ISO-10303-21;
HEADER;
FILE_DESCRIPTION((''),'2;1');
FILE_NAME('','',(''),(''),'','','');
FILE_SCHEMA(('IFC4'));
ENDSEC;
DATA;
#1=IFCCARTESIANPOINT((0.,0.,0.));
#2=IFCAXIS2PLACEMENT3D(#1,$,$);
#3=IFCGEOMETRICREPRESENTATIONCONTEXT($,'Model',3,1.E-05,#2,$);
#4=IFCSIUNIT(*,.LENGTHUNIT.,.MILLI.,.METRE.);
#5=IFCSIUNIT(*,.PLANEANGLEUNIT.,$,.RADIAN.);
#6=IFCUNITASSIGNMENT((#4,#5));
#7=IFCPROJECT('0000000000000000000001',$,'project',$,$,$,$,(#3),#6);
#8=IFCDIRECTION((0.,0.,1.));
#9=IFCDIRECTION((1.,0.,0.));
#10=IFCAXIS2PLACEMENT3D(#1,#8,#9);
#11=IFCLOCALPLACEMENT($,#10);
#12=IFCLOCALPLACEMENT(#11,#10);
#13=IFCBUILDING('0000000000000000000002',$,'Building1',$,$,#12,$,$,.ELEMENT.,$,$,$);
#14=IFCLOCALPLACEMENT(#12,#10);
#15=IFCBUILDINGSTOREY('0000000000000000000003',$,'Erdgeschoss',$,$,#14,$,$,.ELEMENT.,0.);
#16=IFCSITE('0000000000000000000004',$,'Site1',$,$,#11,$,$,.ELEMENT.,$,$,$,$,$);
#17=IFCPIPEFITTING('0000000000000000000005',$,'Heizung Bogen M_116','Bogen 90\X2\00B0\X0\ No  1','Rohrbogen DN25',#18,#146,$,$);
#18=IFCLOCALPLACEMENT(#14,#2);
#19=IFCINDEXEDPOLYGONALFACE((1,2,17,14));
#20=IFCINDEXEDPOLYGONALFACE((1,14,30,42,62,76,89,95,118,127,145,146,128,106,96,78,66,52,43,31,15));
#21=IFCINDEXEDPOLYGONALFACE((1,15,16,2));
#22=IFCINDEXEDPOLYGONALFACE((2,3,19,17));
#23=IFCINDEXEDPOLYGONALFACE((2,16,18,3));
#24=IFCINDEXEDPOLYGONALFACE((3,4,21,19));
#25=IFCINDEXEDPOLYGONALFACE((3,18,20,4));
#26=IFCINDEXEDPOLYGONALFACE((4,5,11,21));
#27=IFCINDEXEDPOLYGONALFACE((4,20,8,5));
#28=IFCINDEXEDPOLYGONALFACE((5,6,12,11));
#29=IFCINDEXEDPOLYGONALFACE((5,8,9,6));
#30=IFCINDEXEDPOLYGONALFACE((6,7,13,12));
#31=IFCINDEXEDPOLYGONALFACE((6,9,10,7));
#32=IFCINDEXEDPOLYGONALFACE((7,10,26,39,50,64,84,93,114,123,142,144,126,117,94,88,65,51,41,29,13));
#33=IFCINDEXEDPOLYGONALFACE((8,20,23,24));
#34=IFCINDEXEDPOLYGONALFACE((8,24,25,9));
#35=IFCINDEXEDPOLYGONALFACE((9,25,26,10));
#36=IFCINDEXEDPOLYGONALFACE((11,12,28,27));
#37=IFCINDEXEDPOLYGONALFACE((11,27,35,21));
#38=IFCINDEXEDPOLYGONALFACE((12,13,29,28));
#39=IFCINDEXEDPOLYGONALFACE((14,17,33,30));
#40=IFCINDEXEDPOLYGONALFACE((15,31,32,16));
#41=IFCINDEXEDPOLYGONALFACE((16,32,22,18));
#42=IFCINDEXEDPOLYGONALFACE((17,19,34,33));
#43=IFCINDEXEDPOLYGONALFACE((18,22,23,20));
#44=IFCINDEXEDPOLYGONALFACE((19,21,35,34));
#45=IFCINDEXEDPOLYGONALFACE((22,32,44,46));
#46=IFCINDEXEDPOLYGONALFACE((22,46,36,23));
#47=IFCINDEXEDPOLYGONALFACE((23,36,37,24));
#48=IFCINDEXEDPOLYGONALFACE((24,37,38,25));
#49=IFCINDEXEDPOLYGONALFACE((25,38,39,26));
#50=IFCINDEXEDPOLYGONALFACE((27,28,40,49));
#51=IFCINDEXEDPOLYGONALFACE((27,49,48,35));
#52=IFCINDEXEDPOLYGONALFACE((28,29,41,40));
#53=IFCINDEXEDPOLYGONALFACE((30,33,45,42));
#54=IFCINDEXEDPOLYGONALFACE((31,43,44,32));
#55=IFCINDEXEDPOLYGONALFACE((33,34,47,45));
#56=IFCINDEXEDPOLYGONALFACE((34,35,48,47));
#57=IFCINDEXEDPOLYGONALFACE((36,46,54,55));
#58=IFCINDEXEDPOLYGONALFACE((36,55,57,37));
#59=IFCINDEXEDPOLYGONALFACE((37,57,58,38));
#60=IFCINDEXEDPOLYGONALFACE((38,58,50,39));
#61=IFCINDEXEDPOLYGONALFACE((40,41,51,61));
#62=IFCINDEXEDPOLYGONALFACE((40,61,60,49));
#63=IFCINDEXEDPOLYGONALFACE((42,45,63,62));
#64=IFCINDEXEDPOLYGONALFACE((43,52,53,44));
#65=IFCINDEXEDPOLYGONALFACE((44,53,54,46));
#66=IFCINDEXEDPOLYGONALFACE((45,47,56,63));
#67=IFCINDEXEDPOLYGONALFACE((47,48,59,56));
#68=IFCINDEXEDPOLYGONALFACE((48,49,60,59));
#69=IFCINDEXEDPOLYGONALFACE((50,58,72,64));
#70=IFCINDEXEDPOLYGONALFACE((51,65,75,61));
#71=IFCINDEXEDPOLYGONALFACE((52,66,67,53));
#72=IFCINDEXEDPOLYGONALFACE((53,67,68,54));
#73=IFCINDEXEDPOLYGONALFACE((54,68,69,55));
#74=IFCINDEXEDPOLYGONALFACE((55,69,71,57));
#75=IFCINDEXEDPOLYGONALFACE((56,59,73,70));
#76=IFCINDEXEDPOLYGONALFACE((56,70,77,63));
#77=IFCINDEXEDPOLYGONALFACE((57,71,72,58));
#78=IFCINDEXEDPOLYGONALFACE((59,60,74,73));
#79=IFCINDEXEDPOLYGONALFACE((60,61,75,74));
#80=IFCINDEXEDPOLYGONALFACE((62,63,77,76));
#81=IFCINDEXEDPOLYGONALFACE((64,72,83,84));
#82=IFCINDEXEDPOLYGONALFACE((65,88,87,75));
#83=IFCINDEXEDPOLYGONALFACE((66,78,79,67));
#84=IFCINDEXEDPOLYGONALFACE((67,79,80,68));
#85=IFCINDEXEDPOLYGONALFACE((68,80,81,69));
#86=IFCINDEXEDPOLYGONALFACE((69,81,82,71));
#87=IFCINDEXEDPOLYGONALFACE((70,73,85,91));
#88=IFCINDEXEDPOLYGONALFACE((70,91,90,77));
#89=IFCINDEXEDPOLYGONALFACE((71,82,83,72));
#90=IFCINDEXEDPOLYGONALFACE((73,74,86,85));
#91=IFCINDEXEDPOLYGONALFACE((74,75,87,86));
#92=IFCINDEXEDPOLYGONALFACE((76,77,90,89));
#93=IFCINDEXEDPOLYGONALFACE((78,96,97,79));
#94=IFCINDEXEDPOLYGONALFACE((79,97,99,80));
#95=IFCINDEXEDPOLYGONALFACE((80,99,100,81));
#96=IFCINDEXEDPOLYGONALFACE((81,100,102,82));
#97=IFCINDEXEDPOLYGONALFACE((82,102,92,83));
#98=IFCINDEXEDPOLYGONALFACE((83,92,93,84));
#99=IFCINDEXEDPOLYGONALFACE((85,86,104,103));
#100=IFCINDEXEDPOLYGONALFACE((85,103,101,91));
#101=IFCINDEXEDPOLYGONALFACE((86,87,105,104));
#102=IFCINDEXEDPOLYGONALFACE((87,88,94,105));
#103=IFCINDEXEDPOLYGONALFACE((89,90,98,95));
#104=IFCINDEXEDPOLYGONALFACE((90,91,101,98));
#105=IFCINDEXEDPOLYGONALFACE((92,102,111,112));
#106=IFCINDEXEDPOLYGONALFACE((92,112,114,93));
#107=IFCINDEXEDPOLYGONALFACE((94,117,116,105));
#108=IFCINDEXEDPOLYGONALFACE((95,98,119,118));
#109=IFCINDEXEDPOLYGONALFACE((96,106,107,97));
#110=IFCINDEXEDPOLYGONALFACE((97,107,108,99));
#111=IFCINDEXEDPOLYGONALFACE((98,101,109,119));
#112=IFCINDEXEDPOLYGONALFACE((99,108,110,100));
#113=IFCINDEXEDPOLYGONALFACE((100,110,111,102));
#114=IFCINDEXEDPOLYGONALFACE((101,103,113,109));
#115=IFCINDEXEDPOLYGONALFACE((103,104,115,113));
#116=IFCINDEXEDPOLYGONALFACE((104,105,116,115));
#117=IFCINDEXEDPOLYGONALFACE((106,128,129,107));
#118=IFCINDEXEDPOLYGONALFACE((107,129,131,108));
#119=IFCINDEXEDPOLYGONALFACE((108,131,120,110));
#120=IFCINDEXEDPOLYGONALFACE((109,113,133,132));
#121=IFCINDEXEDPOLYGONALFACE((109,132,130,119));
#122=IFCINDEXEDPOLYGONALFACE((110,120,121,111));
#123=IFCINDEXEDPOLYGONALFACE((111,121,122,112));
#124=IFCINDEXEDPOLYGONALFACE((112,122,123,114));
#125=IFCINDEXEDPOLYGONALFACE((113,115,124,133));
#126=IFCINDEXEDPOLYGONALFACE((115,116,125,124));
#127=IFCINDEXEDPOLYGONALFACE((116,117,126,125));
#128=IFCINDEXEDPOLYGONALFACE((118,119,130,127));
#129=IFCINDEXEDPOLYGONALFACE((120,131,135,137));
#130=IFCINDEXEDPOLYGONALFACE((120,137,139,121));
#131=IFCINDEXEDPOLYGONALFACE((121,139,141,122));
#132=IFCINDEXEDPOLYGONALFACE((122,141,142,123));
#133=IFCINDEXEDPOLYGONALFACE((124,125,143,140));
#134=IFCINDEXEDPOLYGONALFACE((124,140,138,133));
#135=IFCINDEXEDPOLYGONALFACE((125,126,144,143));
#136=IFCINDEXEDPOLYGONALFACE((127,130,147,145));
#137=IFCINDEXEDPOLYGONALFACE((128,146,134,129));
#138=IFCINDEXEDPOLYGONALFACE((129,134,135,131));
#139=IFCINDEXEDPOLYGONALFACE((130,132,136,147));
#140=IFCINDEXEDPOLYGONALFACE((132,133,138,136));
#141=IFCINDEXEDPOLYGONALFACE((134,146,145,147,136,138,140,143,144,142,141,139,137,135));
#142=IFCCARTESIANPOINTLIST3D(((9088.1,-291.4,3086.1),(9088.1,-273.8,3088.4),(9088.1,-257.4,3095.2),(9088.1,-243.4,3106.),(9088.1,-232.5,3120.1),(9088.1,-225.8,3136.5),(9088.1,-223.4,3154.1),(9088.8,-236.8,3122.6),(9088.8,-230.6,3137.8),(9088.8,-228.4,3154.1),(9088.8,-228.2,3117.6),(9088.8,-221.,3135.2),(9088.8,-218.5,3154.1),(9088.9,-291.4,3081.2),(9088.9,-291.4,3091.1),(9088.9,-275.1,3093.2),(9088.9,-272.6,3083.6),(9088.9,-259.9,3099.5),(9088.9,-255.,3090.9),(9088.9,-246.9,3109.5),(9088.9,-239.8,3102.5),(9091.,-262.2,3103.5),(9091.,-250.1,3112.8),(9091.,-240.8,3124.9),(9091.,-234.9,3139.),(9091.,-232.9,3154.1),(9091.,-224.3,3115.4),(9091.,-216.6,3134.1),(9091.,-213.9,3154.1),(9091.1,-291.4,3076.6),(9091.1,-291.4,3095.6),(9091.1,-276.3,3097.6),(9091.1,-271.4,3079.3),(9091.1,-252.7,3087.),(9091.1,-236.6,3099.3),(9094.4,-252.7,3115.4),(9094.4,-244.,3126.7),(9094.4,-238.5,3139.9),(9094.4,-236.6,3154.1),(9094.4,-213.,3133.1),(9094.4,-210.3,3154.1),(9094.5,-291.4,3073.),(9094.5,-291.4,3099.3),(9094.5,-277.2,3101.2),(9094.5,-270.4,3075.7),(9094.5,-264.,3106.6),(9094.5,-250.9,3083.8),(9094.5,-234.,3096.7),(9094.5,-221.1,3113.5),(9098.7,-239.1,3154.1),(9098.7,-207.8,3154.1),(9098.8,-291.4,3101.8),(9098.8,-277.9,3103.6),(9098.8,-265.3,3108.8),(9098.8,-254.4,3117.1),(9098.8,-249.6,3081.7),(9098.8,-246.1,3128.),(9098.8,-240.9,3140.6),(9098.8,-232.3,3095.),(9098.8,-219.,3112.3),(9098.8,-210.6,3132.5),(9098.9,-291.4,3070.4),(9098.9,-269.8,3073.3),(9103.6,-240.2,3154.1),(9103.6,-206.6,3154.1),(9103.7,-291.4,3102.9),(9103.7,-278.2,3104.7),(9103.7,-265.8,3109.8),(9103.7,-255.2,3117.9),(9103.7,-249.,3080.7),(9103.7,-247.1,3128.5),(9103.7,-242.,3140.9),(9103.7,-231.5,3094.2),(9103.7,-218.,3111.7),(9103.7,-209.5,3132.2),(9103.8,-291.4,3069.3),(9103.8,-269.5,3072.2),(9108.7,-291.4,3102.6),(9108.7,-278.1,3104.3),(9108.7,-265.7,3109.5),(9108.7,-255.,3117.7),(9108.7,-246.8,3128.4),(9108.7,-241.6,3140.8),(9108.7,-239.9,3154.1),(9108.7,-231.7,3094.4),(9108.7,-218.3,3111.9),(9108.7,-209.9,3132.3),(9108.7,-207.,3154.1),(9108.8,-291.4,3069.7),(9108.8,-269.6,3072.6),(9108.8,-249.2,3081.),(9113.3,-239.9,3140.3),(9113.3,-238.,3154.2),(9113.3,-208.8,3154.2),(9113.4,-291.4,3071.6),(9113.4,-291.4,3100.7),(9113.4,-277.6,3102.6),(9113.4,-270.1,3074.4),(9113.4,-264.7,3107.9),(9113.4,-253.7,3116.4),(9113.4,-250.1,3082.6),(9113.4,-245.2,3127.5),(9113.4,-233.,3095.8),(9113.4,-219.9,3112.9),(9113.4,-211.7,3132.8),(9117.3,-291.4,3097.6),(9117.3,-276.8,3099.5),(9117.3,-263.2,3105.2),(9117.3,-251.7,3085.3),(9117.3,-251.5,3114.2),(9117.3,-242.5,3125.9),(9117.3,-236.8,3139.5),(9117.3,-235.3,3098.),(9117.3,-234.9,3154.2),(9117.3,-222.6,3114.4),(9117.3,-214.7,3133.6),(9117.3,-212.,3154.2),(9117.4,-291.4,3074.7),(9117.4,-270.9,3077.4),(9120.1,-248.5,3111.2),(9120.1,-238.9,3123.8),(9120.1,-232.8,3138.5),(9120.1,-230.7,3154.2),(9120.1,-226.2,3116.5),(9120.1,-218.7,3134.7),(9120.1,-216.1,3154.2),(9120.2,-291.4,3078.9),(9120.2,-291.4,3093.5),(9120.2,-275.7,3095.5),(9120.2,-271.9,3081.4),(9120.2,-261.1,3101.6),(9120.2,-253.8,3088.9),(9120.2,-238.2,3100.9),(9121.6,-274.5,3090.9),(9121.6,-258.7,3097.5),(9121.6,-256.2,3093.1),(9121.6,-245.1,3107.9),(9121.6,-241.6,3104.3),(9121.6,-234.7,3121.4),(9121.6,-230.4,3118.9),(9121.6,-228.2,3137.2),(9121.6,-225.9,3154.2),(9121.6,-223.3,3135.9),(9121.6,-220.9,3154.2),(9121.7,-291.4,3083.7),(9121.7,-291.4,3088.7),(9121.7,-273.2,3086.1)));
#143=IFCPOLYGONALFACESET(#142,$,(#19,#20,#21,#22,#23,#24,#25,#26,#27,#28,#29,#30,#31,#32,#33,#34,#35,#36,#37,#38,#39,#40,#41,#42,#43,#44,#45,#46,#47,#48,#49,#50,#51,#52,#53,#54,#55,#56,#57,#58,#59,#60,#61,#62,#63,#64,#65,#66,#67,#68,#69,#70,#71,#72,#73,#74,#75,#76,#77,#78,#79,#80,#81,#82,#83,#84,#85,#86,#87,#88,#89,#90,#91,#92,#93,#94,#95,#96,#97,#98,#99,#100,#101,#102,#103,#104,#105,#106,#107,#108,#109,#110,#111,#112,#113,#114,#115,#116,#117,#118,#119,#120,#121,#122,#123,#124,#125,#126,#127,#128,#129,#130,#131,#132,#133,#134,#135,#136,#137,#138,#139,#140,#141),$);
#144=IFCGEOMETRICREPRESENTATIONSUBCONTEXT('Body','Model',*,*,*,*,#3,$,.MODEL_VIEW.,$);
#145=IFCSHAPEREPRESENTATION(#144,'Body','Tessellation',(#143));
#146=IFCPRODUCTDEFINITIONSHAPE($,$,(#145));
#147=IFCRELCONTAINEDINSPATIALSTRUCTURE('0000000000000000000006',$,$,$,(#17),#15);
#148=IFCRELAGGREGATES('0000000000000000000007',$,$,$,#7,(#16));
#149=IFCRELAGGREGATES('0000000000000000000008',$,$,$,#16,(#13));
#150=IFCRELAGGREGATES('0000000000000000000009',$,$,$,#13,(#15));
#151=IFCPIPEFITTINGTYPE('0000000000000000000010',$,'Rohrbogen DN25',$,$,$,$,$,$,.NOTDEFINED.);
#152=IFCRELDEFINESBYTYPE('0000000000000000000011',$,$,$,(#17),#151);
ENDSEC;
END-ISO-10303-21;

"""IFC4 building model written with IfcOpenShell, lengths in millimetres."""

from ifc_helpers import new_model, entity, si_unit, frame, origin, origin_with_axes, place, context, subcontext, project, spatial, source, transform, mapped, type_object, element, save


model = new_model("IFC4")

# Units and contexts
model_context = context("Model", 3, precision=1e-05, world=origin())
body_context = subcontext(model_context, "Body", "Model", "MODEL_VIEW")
ifc_project = project(units=[si_unit("LENGTHUNIT", "METRE", prefix="MILLI"), si_unit("PLANEANGLEUNIT", "RADIAN")], contexts=[model_context])

# Site, building, storey
site_placement = place(None, origin_with_axes())
site = spatial("IfcSite", under=ifc_project, at=site_placement, Name="Site1", CompositionType="ELEMENT")
building_placement = place(site_placement, origin_with_axes())
building = spatial("IfcBuilding", under=site, at=building_placement, Name="Building1", CompositionType="ELEMENT")
storey_placement = place(building_placement, origin_with_axes())
storey = spatial("IfcBuildingStorey", under=building, at=storey_placement, Name="Erdgeschoss", CompositionType="ELEMENT", Elevation=0.0)

# Pipe fitting
pipe_fitting_type = type_object("IfcPipeFittingType", Name="Rohrbogen DN25", PredefinedType="NOTDEFINED")
shared_shape_1 = source(origin_with_axes(), body_context, "Body", "SolidModel", [
    entity("IfcRevolvedAreaSolid", entity("IfcCircleProfileDef", "AREA", None, entity("IfcAxis2Placement2D", entity("IfcCartesianPoint", [0.0, 0.0]), entity("IfcDirection", [1.0, 0.0])), 16.9), entity("IfcAxis2Placement3D", entity("IfcCartesianPoint", [-42.4, 0.0, 25.6]), entity("IfcDirection", [1.0, 0.0, 0.0]), entity("IfcDirection", [0.0, -0.999999, 0.001364])), entity("IfcAxis1Placement", entity("IfcCartesianPoint", [0.0, 68.0, 0.0]), entity("IfcDirection", [-1.0, 0.0, 0.0])), 1.570796),
])
pipe_fitting_1_placement = place(storey_placement, frame((9105.0, -249.0, 3111.7), z_axis=(0.0, 0.0, 1.0), x_axis=(1.0, 0.0, 0.0)))
element("IfcPipeFitting", 1, at=pipe_fitting_1_placement, inside=storey, type_object=pipe_fitting_type, Name="Heizung Bogen M_116", Description="Bogen 90° No  1", ObjectType="Rohrbogen DN25", context=body_context, shape_type="MappedRepresentation", body=[
    mapped(shared_shape_1, transform((0.0, 0.0, 0.0), x_axis=(0.0, 1.0, 0.0), y_axis=(1.0, 0.0, 0.0), z_axis=(0.0, 0.0, -1.0), scale=1.0)),
])

save(model, "model.ifc")
